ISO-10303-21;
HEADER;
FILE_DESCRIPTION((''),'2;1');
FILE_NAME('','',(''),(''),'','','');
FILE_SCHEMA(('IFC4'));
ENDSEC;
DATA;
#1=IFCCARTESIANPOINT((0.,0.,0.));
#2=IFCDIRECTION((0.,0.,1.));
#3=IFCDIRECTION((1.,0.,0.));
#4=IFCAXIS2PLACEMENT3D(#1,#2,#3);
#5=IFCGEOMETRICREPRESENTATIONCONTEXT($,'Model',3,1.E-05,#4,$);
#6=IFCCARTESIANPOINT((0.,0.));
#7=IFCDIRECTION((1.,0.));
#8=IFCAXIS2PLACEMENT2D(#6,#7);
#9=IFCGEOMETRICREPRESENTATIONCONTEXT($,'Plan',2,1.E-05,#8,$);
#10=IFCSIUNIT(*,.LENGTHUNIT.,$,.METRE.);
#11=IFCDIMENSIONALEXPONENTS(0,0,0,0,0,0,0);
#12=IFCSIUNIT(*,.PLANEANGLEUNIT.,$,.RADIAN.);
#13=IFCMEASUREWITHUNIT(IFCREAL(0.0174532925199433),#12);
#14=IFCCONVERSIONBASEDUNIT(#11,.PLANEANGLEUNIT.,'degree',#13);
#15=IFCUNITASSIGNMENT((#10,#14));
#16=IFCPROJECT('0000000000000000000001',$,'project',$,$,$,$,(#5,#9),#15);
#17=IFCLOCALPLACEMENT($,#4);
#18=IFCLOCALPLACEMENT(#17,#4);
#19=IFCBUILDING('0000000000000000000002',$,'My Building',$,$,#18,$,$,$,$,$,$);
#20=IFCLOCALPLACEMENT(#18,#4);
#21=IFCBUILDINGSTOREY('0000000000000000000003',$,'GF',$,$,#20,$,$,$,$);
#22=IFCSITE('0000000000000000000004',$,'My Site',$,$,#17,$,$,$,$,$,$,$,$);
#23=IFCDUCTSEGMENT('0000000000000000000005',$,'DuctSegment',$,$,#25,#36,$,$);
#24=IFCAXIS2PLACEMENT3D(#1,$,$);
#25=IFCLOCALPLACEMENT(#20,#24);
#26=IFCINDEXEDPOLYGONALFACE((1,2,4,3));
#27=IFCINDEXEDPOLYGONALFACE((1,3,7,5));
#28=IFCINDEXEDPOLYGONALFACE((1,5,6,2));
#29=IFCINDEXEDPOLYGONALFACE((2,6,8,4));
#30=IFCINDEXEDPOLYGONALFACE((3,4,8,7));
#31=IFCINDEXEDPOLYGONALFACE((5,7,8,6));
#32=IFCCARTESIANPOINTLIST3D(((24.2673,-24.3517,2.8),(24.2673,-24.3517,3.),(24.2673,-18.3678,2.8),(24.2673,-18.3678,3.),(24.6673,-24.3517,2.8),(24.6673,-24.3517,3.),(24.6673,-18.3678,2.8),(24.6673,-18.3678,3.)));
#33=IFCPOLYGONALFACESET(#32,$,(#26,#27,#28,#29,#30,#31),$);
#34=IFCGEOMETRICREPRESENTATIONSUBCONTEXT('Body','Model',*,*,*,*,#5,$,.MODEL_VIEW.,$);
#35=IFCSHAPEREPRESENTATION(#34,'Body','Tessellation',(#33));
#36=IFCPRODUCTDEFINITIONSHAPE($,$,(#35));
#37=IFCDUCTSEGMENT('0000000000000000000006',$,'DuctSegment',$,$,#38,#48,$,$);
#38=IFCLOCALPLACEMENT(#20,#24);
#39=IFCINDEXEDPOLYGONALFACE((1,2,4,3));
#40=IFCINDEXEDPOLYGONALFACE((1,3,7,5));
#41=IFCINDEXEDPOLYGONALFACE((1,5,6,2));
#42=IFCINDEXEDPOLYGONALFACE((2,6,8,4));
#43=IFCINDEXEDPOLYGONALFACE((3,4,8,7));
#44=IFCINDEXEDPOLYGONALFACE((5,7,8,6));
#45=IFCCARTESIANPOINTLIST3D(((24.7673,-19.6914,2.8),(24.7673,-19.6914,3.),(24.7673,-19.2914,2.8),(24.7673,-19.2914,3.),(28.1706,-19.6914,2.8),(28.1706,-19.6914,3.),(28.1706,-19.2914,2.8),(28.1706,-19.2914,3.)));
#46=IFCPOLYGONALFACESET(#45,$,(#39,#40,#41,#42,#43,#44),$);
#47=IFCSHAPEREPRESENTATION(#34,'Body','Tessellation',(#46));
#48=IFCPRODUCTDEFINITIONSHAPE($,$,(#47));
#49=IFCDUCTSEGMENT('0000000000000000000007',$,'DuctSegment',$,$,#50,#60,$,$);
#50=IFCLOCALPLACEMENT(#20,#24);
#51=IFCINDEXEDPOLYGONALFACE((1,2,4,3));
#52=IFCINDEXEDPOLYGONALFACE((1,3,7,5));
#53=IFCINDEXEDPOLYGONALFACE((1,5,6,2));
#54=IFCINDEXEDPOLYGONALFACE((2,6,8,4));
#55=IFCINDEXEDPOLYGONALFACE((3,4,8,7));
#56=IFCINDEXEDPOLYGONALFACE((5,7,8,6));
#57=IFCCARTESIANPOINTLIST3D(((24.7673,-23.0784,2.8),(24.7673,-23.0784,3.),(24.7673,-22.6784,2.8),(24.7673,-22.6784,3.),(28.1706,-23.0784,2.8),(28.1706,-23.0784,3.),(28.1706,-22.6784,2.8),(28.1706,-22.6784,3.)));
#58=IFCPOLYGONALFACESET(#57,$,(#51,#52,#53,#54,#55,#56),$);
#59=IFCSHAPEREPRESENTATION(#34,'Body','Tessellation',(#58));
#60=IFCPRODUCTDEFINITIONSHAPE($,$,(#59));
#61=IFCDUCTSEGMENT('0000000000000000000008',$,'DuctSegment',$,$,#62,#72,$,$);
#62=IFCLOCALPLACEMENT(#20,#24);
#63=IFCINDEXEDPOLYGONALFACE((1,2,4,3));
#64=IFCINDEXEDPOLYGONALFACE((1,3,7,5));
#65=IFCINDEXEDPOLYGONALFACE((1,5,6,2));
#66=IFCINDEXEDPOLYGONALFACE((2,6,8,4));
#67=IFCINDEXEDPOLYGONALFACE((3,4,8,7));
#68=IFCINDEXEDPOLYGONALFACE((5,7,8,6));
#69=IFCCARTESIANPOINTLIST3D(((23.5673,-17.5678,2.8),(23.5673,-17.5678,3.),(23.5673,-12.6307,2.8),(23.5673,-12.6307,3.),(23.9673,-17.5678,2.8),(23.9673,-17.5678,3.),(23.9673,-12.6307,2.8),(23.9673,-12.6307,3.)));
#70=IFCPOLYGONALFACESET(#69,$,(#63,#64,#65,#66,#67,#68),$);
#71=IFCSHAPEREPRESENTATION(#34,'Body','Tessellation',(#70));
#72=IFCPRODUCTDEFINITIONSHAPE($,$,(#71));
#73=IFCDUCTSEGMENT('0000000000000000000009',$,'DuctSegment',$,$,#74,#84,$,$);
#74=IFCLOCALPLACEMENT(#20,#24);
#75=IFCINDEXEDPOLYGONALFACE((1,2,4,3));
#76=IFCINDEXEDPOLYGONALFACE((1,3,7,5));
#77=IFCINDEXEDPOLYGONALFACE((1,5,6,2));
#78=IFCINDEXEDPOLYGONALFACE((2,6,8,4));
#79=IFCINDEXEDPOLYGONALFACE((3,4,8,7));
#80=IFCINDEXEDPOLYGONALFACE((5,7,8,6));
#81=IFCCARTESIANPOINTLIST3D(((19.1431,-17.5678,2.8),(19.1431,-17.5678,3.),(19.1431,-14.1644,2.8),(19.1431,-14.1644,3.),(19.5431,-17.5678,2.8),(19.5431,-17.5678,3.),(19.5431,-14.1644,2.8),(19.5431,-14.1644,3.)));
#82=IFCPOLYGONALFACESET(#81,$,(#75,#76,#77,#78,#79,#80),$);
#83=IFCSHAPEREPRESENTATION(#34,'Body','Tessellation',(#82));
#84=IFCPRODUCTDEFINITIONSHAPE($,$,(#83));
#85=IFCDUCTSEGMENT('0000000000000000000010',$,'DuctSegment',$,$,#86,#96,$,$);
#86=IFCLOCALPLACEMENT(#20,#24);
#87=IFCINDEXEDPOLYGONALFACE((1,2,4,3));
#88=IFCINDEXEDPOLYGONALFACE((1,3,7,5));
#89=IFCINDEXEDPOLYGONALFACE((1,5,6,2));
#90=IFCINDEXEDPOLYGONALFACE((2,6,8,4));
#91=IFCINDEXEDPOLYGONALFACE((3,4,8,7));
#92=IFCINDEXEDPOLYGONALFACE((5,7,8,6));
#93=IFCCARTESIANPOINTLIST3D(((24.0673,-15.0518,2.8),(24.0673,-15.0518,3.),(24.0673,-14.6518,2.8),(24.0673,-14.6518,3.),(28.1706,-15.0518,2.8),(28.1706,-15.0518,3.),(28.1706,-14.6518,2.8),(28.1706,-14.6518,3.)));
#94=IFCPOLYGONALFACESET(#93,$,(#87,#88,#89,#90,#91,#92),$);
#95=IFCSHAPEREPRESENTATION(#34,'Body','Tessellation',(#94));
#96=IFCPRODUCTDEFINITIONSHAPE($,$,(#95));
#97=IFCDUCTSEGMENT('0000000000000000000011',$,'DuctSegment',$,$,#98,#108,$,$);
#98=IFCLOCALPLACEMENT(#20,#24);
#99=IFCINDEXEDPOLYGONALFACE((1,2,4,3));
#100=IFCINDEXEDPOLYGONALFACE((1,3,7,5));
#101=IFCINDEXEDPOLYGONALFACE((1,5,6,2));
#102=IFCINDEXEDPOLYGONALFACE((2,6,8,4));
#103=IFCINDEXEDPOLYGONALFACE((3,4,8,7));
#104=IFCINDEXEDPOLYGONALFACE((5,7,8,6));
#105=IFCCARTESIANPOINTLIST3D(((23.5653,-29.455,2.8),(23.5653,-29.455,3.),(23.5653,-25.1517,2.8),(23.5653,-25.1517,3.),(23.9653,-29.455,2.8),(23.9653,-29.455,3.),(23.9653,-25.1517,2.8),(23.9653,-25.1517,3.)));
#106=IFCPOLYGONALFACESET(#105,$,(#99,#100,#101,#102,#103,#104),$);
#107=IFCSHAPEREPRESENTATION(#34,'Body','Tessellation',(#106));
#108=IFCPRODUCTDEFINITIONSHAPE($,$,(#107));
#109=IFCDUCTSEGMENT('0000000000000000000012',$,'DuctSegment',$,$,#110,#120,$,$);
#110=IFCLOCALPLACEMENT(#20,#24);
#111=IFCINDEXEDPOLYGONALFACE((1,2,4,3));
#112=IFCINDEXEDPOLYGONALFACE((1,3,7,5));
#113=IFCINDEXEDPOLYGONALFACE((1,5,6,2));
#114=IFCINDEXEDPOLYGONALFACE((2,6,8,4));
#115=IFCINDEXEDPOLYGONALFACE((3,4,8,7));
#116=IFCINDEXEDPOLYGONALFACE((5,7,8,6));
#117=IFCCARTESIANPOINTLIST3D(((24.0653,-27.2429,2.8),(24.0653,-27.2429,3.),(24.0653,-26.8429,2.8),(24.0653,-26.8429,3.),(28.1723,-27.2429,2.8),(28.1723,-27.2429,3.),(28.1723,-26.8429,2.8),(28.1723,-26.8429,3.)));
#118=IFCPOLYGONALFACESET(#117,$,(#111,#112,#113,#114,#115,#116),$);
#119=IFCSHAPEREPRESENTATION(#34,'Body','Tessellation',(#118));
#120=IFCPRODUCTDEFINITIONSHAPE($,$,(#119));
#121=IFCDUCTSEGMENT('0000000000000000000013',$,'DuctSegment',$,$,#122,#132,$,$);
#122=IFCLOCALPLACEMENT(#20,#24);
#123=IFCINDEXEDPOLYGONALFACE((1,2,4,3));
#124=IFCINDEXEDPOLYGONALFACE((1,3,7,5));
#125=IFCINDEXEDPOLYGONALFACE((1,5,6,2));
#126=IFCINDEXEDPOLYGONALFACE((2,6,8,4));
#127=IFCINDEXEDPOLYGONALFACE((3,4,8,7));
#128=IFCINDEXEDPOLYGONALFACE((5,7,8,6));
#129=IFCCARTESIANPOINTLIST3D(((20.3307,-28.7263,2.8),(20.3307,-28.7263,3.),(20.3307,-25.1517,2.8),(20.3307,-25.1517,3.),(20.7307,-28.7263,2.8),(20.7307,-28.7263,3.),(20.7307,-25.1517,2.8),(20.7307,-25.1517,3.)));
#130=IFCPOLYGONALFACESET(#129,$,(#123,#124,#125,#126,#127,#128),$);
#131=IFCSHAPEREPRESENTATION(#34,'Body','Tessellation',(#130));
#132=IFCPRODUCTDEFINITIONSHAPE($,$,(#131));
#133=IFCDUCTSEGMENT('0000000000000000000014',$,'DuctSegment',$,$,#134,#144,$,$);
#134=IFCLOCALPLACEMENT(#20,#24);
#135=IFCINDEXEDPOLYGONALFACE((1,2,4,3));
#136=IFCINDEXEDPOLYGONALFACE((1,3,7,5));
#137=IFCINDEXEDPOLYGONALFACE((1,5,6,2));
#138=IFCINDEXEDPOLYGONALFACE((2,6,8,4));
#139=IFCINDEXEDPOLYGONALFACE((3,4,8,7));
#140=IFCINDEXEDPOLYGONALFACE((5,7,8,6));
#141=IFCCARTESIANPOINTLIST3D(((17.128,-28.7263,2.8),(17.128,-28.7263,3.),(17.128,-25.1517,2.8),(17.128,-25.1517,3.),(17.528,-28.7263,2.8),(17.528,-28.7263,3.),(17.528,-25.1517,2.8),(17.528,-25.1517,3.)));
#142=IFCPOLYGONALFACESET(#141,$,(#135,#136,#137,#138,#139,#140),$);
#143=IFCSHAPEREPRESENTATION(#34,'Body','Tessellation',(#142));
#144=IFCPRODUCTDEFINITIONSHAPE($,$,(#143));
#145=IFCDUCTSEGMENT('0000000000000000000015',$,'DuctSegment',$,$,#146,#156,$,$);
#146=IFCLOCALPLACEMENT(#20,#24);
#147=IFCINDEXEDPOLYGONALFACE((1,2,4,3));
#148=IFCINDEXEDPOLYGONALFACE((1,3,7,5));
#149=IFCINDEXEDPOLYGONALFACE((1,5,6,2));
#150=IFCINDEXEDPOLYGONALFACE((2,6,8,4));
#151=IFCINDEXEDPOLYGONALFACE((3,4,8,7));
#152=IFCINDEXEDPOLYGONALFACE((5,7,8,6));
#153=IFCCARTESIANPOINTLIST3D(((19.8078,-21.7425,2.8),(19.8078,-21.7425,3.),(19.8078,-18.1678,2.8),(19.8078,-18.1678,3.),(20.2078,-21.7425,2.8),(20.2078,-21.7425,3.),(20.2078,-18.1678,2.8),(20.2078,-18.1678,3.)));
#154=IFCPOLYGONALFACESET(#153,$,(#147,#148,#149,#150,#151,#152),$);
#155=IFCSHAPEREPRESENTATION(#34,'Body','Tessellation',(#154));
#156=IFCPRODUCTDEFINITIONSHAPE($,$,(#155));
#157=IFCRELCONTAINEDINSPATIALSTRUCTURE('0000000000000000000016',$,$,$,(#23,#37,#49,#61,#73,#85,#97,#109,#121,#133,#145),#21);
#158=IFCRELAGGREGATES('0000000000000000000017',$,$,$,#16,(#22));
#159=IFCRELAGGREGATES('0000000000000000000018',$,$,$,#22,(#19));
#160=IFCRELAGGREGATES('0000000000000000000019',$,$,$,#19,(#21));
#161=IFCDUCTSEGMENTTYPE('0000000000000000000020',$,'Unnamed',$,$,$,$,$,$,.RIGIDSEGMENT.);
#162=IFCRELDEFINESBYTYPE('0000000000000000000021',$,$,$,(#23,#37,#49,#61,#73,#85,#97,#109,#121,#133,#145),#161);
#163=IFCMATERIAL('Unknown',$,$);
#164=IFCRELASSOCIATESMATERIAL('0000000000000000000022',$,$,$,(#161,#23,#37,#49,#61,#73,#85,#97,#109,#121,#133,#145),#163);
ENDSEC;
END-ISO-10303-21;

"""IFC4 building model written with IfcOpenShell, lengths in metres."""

from ifc_helpers import new_model, entity, si_unit, converted_unit, frame, origin_with_axes, origin_2d_with_axis, place, context, subcontext, project, spatial, rectangle, extrude, material, material_profile, profile_set, profile_usage, type_object, element, save


model = new_model("IFC4")

# Units and contexts
model_context = context("Model", 3, precision=1e-05, world=origin_with_axes())
plan_context = context("Plan", 2, precision=1e-05, world=origin_2d_with_axis())
body_context_1 = subcontext(model_context, "Body", "Model", "MODEL_VIEW")
ifc_project = project(units=[si_unit("LENGTHUNIT", "METRE"), converted_unit("PLANEANGLEUNIT", "degree", entity("IfcReal", 0.0174532925199433), si_unit("PLANEANGLEUNIT", "RADIAN"), dimensions=[0, 0, 0, 0, 0, 0, 0])], contexts=[model_context, plan_context])

# Site, building, storey
site_placement = place(None, origin_with_axes())
site = spatial("IfcSite", under=ifc_project, at=site_placement, Name="My Site")
building_placement = place(site_placement, origin_with_axes())
building = spatial("IfcBuilding", under=site, at=building_placement, Name="My Building")
storey_placement = place(building_placement, origin_with_axes())
storey = spatial("IfcBuildingStorey", under=building, at=storey_placement, Name="GF")

# Shared definitions
ifc_material = material(Name="Unknown")

# Duct segments
ifc_material_profile_1 = material_profile(ifc_material, rectangle(XDim=0.4, YDim=0.2))
ifc_profile_set_1 = profile_set([ifc_material_profile_1])
duct_segment_type = type_object("IfcDuctSegmentType", Name="Unnamed", PredefinedType="RIGIDSEGMENT", material=ifc_profile_set_1)
ifc_profile_usage_1 = profile_usage(ifc_profile_set_1, cardinal=5)
duct_segment_1_placement = place(storey_placement, frame((24.4673, -24.3517, 2.9), z_axis=(0.0, 1.0, 0.0), x_axis=(-1.0, 0.0, 0.0)))
element("IfcDuctSegment", 1, at=duct_segment_1_placement, inside=storey, type_object=duct_segment_type, material=ifc_profile_usage_1, Name="DuctSegment", context=body_context_1, shape_type="SweptSolid", body=[
    extrude(rectangle(XDim=0.4, YDim=0.2), origin_with_axes(), (0.0, 0.0, 1.0), 5.9839),
])
ifc_profile_usage_2 = profile_usage(ifc_profile_set_1, cardinal=5)
duct_segment_2_placement = place(storey_placement, frame((24.7673, -19.4914, 2.9), z_axis=(1.0, 0.0, 0.0), x_axis=(0.0, 1.0, 0.0)))
element("IfcDuctSegment", 2, at=duct_segment_2_placement, inside=storey, type_object=duct_segment_type, material=ifc_profile_usage_2, Name="DuctSegment", context=body_context_1, shape_type="SweptSolid", body=[
    extrude(rectangle(XDim=0.4, YDim=0.2), origin_with_axes(), (0.0, 0.0, 1.0), 3.4033),
])
ifc_profile_usage_3 = profile_usage(ifc_profile_set_1, cardinal=5)
duct_segment_3_placement = place(storey_placement, frame((24.7673, -22.8784, 2.9), z_axis=(1.0, 0.0, 0.0), x_axis=(0.0, 1.0, 0.0)))
element("IfcDuctSegment", 3, at=duct_segment_3_placement, inside=storey, type_object=duct_segment_type, material=ifc_profile_usage_3, Name="DuctSegment", context=body_context_1, shape_type="SweptSolid", body=[
    extrude(rectangle(XDim=0.4, YDim=0.2), origin_with_axes(), (0.0, 0.0, 1.0), 3.4033),
])
ifc_profile_usage_4 = profile_usage(ifc_profile_set_1, cardinal=5)
duct_segment_4_placement = place(storey_placement, frame((23.7673, -17.5678, 2.9), z_axis=(0.0, 1.0, 0.0), x_axis=(-1.0, 0.0, 0.0)))
element("IfcDuctSegment", 4, at=duct_segment_4_placement, inside=storey, type_object=duct_segment_type, material=ifc_profile_usage_4, Name="DuctSegment", context=body_context_1, shape_type="SweptSolid", body=[
    extrude(rectangle(XDim=0.4, YDim=0.2), origin_with_axes(), (0.0, 0.0, 1.0), 4.937),
])
ifc_profile_usage_5 = profile_usage(ifc_profile_set_1, cardinal=5)
duct_segment_5_placement = place(storey_placement, frame((19.3431, -17.5678, 2.9), z_axis=(0.0, 1.0, 0.0), x_axis=(-1.0, 0.0, 0.0)))
element("IfcDuctSegment", 5, at=duct_segment_5_placement, inside=storey, type_object=duct_segment_type, material=ifc_profile_usage_5, Name="DuctSegment", context=body_context_1, shape_type="SweptSolid", body=[
    extrude(rectangle(XDim=0.4, YDim=0.2), origin_with_axes(), (0.0, 0.0, 1.0), 3.4033),
])
ifc_profile_usage_6 = profile_usage(ifc_profile_set_1, cardinal=5)
duct_segment_6_placement = place(storey_placement, frame((24.0673, -14.8518, 2.9), z_axis=(1.0, 0.0, 0.0), x_axis=(0.0, 1.0, 0.0)))
element("IfcDuctSegment", 6, at=duct_segment_6_placement, inside=storey, type_object=duct_segment_type, material=ifc_profile_usage_6, Name="DuctSegment", context=body_context_1, shape_type="SweptSolid", body=[
    extrude(rectangle(XDim=0.4, YDim=0.2), origin_with_axes(), (0.0, 0.0, 1.0), 4.1033),
])
ifc_profile_usage_7 = profile_usage(ifc_profile_set_1, cardinal=5)
duct_segment_7_placement = place(storey_placement, frame((23.7653, -25.1517, 2.9), z_axis=(0.0, -1.0, 0.0), x_axis=(1.0, 0.0, 0.0)))
element("IfcDuctSegment", 7, at=duct_segment_7_placement, inside=storey, type_object=duct_segment_type, material=ifc_profile_usage_7, Name="DuctSegment", context=body_context_1, shape_type="SweptSolid", body=[
    extrude(rectangle(XDim=0.4, YDim=0.2), origin_with_axes(), (0.0, 0.0, 1.0), 4.3034),
])
ifc_profile_usage_8 = profile_usage(ifc_profile_set_1, cardinal=5)
duct_segment_8_placement = place(storey_placement, frame((24.0653, -27.0429, 2.9), z_axis=(1.0, 0.0, 0.0), x_axis=(0.0, 1.0, 0.0)))
element("IfcDuctSegment", 8, at=duct_segment_8_placement, inside=storey, type_object=duct_segment_type, material=ifc_profile_usage_8, Name="DuctSegment", context=body_context_1, shape_type="SweptSolid", body=[
    extrude(rectangle(XDim=0.4, YDim=0.2), origin_with_axes(), (0.0, 0.0, 1.0), 4.107),
])
ifc_profile_usage_9 = profile_usage(ifc_profile_set_1, cardinal=5)
duct_segment_9_placement = place(storey_placement, frame((20.5307, -25.1517, 2.9), z_axis=(0.0, -1.0, 0.0), x_axis=(1.0, 0.0, 0.0)))
element("IfcDuctSegment", 9, at=duct_segment_9_placement, inside=storey, type_object=duct_segment_type, material=ifc_profile_usage_9, Name="DuctSegment", context=body_context_1, shape_type="SweptSolid", body=[
    extrude(rectangle(XDim=0.4, YDim=0.2), origin_with_axes(), (0.0, 0.0, 1.0), 3.5747),
])
ifc_profile_usage_10 = profile_usage(ifc_profile_set_1, cardinal=5)
duct_segment_10_placement = place(storey_placement, frame((17.328, -25.1517, 2.9), z_axis=(0.0, -1.0, 0.0), x_axis=(1.0, 0.0, 0.0)))
element("IfcDuctSegment", 10, at=duct_segment_10_placement, inside=storey, type_object=duct_segment_type, material=ifc_profile_usage_10, Name="DuctSegment", context=body_context_1, shape_type="SweptSolid", body=[
    extrude(rectangle(XDim=0.4, YDim=0.2), origin_with_axes(), (0.0, 0.0, 1.0), 3.5747),
])
ifc_profile_usage_11 = profile_usage(ifc_profile_set_1, cardinal=5)
duct_segment_11_placement = place(storey_placement, frame((20.0078, -18.1678, 2.9), z_axis=(0.0, -1.0, 0.0), x_axis=(1.0, 0.0, 0.0)))
element("IfcDuctSegment", 11, at=duct_segment_11_placement, inside=storey, type_object=duct_segment_type, material=ifc_profile_usage_11, Name="DuctSegment", context=body_context_1, shape_type="SweptSolid", body=[
    extrude(rectangle(XDim=0.4, YDim=0.2), origin_with_axes(), (0.0, 0.0, 1.0), 3.5747),
])

save(model, "model.ifc")
